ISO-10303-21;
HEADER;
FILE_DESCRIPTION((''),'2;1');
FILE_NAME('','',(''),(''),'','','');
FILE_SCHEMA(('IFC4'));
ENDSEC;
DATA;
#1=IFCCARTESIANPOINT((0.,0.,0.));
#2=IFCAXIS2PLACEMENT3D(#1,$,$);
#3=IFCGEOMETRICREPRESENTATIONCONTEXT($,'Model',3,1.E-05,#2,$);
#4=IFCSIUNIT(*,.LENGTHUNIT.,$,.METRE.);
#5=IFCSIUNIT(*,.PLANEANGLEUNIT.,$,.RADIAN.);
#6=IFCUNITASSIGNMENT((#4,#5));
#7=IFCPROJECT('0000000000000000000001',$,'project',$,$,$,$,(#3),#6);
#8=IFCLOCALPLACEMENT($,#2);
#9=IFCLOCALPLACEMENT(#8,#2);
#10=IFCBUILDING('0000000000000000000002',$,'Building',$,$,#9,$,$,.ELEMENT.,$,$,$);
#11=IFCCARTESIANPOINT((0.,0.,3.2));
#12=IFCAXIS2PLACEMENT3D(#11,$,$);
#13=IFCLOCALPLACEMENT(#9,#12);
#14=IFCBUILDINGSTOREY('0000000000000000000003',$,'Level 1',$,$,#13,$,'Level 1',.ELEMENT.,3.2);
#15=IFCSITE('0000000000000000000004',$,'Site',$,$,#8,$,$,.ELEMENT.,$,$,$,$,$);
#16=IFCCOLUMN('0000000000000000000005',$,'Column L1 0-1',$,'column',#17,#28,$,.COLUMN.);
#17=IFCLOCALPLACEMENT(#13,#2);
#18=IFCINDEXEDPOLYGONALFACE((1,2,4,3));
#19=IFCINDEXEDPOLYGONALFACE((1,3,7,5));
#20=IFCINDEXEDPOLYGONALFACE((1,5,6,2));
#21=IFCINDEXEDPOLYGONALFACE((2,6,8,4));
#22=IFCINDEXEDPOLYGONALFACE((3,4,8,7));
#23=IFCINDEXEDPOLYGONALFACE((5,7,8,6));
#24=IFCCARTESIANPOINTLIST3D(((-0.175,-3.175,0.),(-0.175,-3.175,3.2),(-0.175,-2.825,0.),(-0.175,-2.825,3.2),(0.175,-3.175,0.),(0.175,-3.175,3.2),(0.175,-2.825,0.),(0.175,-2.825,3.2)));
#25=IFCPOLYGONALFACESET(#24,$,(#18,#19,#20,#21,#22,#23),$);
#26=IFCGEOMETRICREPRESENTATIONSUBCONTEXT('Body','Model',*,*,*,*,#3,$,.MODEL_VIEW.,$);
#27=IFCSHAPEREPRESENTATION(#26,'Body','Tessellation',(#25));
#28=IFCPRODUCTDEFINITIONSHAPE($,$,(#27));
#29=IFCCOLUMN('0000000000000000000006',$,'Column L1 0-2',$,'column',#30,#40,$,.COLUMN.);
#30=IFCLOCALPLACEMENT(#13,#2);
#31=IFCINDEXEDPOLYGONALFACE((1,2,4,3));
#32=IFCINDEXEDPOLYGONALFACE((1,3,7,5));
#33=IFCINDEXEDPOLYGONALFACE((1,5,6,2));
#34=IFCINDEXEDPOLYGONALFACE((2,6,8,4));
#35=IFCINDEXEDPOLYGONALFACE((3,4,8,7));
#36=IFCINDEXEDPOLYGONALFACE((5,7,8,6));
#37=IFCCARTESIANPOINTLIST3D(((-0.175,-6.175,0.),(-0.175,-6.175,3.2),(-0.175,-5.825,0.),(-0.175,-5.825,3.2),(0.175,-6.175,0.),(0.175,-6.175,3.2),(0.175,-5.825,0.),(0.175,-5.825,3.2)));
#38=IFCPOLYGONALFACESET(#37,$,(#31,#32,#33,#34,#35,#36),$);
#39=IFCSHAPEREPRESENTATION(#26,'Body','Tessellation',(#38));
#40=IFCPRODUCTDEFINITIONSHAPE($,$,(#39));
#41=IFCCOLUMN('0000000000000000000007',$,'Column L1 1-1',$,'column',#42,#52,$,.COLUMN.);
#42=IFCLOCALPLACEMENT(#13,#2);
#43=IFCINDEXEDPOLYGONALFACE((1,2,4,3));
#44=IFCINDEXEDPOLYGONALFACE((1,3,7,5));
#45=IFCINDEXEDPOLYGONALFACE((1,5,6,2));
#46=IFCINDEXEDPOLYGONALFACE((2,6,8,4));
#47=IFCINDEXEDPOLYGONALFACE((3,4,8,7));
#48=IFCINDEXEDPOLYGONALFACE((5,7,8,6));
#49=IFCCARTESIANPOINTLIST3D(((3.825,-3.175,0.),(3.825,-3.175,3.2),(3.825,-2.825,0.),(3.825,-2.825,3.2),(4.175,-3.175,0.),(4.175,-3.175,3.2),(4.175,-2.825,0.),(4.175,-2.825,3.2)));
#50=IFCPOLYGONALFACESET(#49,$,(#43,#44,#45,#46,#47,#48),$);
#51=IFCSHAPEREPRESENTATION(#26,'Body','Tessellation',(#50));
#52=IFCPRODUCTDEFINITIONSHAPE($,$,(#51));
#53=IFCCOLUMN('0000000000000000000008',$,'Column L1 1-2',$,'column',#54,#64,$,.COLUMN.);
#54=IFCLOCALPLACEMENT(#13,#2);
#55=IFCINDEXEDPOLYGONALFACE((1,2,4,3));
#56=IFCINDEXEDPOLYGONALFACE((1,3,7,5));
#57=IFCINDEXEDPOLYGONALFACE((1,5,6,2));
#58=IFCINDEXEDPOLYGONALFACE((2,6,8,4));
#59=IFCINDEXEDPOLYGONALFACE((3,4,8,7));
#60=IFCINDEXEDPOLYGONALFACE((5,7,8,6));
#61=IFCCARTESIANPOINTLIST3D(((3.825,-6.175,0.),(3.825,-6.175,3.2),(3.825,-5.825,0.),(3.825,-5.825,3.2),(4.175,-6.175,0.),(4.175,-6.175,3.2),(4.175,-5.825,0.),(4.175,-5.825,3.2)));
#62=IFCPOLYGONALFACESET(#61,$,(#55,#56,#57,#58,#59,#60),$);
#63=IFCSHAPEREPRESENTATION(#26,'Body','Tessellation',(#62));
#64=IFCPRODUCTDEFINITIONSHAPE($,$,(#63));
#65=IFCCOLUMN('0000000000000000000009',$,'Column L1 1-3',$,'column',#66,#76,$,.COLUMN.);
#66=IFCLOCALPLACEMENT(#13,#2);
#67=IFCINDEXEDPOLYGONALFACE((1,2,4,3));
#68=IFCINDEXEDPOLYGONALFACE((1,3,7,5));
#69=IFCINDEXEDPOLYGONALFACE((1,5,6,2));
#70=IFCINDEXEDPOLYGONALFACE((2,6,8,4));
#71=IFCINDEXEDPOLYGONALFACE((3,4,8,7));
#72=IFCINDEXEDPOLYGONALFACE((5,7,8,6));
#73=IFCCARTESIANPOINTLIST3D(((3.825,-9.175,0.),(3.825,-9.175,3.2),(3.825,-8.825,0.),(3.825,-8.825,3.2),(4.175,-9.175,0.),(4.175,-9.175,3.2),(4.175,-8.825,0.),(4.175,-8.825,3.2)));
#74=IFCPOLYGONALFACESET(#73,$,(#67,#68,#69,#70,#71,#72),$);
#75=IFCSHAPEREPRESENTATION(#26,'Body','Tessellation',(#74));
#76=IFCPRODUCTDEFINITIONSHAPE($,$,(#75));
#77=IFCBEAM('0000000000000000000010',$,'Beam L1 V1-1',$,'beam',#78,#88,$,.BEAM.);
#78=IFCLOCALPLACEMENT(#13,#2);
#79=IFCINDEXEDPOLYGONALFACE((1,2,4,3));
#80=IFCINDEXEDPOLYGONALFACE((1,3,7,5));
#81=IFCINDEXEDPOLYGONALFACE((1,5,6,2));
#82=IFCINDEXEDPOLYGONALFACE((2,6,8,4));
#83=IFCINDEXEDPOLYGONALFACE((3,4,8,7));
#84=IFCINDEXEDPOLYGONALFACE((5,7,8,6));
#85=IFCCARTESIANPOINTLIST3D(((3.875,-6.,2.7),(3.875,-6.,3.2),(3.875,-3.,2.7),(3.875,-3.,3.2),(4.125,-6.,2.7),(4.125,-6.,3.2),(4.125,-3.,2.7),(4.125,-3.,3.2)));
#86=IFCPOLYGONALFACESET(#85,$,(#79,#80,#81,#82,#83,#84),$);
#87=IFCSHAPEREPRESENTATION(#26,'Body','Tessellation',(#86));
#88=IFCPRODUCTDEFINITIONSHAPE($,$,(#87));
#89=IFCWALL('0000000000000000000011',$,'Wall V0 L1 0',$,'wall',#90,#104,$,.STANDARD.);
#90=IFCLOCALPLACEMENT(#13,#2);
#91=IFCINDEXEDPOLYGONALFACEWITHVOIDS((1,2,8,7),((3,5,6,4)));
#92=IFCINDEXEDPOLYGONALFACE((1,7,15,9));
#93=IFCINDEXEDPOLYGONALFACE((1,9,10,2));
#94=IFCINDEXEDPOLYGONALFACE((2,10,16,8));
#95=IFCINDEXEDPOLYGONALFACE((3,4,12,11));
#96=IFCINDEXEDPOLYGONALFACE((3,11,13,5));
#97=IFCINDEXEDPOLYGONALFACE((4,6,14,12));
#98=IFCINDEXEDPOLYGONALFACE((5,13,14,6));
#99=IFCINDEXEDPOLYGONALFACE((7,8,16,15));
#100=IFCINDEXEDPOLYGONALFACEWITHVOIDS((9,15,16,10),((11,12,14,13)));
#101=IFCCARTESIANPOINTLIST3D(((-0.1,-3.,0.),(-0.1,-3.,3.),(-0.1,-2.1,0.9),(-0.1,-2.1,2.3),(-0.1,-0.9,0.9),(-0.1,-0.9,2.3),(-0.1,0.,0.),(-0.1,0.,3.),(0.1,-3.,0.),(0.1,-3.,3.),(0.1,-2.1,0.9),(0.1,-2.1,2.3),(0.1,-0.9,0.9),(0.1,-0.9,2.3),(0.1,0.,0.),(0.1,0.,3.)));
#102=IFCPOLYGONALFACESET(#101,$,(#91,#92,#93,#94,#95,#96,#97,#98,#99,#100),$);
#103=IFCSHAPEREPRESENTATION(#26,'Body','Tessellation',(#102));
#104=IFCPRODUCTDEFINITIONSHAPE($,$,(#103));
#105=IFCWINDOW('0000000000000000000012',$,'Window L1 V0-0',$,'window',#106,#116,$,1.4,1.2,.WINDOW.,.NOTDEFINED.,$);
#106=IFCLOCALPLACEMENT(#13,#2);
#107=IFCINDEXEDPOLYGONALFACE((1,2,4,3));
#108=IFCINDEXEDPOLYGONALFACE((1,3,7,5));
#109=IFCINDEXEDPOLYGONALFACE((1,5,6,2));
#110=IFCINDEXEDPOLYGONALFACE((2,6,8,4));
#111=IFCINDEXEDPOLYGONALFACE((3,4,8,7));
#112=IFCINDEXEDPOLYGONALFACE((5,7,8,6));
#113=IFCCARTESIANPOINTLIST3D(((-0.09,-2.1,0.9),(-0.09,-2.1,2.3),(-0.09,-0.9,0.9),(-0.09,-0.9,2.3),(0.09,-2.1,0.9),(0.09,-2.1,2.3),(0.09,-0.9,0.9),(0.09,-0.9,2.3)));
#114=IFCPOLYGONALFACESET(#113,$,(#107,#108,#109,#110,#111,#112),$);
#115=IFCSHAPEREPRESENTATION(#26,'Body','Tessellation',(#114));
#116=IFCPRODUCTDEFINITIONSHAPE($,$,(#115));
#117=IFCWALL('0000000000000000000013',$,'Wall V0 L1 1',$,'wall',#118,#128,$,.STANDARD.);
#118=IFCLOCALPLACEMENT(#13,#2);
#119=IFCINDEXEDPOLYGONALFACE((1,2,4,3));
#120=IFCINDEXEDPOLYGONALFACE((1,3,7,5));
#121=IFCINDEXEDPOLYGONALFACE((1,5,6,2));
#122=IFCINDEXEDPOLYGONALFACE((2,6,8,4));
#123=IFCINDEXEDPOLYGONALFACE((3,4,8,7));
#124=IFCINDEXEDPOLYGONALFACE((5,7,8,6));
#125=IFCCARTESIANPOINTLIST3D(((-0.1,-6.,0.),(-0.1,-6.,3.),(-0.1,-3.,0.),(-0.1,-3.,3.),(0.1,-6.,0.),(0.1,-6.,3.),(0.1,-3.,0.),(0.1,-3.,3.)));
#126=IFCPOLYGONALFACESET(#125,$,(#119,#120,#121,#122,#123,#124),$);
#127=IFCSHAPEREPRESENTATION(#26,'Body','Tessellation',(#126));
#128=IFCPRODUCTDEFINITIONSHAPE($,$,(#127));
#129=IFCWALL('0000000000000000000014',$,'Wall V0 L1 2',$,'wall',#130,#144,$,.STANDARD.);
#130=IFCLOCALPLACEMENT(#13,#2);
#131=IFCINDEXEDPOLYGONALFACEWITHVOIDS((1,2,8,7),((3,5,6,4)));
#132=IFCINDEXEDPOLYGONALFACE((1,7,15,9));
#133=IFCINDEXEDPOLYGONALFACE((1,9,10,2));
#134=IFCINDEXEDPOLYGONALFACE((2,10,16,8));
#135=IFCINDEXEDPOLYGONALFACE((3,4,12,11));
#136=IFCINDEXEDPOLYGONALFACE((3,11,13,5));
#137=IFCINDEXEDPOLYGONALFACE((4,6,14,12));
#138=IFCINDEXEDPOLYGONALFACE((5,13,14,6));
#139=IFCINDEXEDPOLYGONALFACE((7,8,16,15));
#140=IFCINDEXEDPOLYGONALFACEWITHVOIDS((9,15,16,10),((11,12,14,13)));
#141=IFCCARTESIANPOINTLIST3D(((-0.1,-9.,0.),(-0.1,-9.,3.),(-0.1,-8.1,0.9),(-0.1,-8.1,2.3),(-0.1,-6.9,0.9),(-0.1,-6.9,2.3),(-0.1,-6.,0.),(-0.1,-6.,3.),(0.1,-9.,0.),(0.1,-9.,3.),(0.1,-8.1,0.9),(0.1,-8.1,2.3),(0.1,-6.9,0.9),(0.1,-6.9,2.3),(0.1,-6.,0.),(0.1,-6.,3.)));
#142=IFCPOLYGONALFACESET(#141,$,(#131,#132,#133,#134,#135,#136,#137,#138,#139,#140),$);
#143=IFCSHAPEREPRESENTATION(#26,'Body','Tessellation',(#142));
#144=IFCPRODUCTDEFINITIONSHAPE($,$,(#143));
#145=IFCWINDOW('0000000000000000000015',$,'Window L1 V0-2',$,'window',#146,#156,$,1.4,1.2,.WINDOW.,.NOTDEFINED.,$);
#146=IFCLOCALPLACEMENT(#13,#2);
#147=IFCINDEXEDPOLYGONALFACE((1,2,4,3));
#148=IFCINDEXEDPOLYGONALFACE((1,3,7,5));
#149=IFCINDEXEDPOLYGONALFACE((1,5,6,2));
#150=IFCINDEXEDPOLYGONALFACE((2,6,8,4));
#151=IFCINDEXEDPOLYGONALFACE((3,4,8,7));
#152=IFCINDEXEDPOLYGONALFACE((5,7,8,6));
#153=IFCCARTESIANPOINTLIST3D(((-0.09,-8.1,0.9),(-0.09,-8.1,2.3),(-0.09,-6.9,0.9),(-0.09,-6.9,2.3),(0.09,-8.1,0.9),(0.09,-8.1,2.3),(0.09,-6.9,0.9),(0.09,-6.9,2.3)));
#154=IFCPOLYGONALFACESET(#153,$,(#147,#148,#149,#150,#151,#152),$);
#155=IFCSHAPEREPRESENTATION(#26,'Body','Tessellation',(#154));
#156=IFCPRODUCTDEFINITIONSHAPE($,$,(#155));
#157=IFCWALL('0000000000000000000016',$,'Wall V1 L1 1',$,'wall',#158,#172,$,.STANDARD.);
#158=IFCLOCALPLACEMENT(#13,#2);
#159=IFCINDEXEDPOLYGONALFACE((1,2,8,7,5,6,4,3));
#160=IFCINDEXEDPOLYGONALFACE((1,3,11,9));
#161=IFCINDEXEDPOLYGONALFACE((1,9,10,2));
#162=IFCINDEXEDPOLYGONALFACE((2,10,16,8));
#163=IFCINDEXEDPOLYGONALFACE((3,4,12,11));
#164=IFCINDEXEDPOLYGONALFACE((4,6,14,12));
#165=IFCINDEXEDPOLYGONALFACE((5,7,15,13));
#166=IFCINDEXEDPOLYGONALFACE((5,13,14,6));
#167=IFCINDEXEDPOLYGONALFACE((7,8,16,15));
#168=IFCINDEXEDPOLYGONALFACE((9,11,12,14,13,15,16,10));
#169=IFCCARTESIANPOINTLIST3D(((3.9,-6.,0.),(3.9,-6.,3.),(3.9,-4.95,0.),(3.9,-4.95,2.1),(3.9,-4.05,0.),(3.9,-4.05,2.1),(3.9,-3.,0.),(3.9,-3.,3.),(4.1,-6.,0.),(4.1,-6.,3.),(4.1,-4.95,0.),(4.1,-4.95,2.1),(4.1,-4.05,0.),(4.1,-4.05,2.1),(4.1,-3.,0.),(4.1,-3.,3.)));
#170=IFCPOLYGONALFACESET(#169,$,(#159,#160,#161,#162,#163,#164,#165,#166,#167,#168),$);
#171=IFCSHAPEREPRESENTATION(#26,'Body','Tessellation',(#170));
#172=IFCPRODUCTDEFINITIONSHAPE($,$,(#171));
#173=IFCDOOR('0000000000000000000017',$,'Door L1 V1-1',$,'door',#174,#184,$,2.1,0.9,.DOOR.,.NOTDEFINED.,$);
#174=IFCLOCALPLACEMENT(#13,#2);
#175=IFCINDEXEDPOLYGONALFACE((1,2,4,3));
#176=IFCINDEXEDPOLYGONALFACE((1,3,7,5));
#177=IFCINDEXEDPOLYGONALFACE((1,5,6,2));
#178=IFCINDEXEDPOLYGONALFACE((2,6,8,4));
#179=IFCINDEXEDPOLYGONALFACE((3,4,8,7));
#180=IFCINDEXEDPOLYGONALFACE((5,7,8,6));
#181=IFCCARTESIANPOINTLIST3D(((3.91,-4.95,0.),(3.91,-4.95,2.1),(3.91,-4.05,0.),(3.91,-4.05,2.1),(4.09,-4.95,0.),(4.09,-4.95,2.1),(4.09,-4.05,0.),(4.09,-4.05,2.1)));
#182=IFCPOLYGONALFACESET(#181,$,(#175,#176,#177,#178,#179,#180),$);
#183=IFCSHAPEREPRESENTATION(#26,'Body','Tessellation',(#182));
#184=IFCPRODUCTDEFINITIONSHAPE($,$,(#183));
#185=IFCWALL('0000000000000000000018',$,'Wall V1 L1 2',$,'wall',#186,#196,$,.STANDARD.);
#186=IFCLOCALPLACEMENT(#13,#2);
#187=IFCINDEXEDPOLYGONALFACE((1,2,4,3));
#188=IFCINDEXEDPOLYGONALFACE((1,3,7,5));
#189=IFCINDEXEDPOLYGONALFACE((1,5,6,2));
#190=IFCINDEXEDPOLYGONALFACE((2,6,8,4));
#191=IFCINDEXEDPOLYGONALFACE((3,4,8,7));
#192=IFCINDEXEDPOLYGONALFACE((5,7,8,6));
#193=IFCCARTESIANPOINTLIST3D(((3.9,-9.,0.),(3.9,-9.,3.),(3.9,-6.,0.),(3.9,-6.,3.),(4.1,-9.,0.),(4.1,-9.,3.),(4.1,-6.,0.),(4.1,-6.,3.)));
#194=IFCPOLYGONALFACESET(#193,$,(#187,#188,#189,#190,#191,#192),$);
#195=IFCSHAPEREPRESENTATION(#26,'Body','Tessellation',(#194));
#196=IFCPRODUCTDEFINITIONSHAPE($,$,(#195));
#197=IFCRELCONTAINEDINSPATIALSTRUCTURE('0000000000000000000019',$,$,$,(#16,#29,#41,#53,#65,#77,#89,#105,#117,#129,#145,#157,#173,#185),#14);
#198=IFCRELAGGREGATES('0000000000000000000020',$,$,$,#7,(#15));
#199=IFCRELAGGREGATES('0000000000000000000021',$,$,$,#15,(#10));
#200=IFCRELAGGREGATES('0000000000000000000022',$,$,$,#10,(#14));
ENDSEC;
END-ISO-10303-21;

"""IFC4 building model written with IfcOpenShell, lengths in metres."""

from ifc_helpers import new_model, si_unit, frame, frame_2d, origin, origin_2d, place, context, subcontext, project, spatial, rectangle, extrude, element, fill, save


model = new_model("IFC4")

# Units and contexts
model_context = context("Model", 3, precision=1e-05, world=origin())
body_context = subcontext(model_context, "Body", "Model", "MODEL_VIEW")
ifc_project = project(units=[si_unit("LENGTHUNIT", "METRE"), si_unit("PLANEANGLEUNIT", "RADIAN")], contexts=[model_context])

# Site, building, storey
site_placement = place(None, origin())
site = spatial("IfcSite", under=ifc_project, at=site_placement, Name="Site", CompositionType="ELEMENT")
building_placement = place(site_placement, origin())
building = spatial("IfcBuilding", under=site, at=building_placement, Name="Building", CompositionType="ELEMENT")
storey_placement = place(building_placement, frame((0.0, 0.0, 3.2)))
storey = spatial("IfcBuildingStorey", under=building, at=storey_placement, Name="Level 1", LongName="Level 1", CompositionType="ELEMENT", Elevation=3.2)

# Columns
for number, where, name in (
    (1, (0.0, -3.0, 0.0), "Column L1 0-1"),
    (2, (0.0, -6.0, 0.0), "Column L1 0-2"),
    (3, (4.0, -3.0, 0.0), "Column L1 1-1"),
    (4, (4.0, -6.0, 0.0), "Column L1 1-2"),
    (5, (4.0, -9.0, 0.0), "Column L1 1-3"),
):
    element("IfcColumn", number, at=place(storey_placement, frame(where)), inside=storey, Name=name, ObjectType="column", PredefinedType="COLUMN", context=body_context, shape_type="SweptSolid", body=[
        extrude(rectangle(XDim=0.35, YDim=0.35, at=origin_2d()), origin(), (0.0, 0.0, 1.0), 3.2),
    ])

# Beam
beam_placement = place(storey_placement, frame((4.0, -3.0, 2.95), z_axis=(0.0, -1.0, 0.0), x_axis=(0.0, 0.0, 1.0)))
element("IfcBeam", 6, at=beam_placement, inside=storey, Name="Beam L1 V1-1", ObjectType="beam", PredefinedType="BEAM", context=body_context, shape_type="SweptSolid", body=[
    extrude(rectangle(XDim=0.5, YDim=0.25, at=origin_2d()), origin(), (0.0, 0.0, 1.0), 3.0),
])

# Wall, opening, window
wall_1_placement = place(storey_placement, frame((0.0, 0.0, 0.0), z_axis=(0.0, 0.0, 1.0), x_axis=(0.0, -1.0, 0.0)))
wall_1 = element("IfcWall", 7, at=wall_1_placement, inside=storey, Name="Wall V0 L1 0", ObjectType="wall", PredefinedType="STANDARD", context=body_context, shape_type="SweptSolid", body=[
    extrude(rectangle(XDim=3.0, YDim=0.2, at=frame_2d((1.5, 0.0))), origin(), (0.0, 0.0, 1.0), 3.0),
])
opening_1_placement = place(storey_placement, frame((0.0, -1.5, 0.9), z_axis=(0.0, 0.0, 1.0), x_axis=(0.0, -1.0, 0.0)))
opening_1 = element("IfcOpeningElement", 8, at=opening_1_placement, cuts=wall_1, ObjectType="Opening", PredefinedType="OPENING", context=body_context, shape_type="SweptSolid", body=[
    extrude(rectangle(XDim=1.2, YDim=0.22, at=origin_2d()), origin(), (0.0, 0.0, 1.0), 1.4),
])
window_1_placement = place(storey_placement, frame((0.0, -1.5, 0.9), z_axis=(0.0, 0.0, 1.0), x_axis=(0.0, -1.0, 0.0)))
window_1 = element("IfcWindow", 9, at=window_1_placement, inside=storey, Name="Window L1 V0-0", ObjectType="window", OverallHeight=1.4, OverallWidth=1.2, PartitioningType="NOTDEFINED", PredefinedType="WINDOW", context=body_context, shape_type="SweptSolid", body=[
    extrude(rectangle(XDim=1.2, YDim=0.18, at=origin_2d()), origin(), (0.0, 0.0, 1.0), 1.4),
])
fill(opening_1, window_1)

# Wall
wall_2_placement = place(storey_placement, frame((0.0, -3.0, 0.0), z_axis=(0.0, 0.0, 1.0), x_axis=(0.0, -1.0, 0.0)))
element("IfcWall", 10, at=wall_2_placement, inside=storey, Name="Wall V0 L1 1", ObjectType="wall", PredefinedType="STANDARD", context=body_context, shape_type="SweptSolid", body=[
    extrude(rectangle(XDim=3.0, YDim=0.2, at=frame_2d((1.5, 0.0))), origin(), (0.0, 0.0, 1.0), 3.0),
])

# Wall, opening, window
wall_3_placement = place(storey_placement, frame((0.0, -6.0, 0.0), z_axis=(0.0, 0.0, 1.0), x_axis=(0.0, -1.0, 0.0)))
wall_3 = element("IfcWall", 11, at=wall_3_placement, inside=storey, Name="Wall V0 L1 2", ObjectType="wall", PredefinedType="STANDARD", context=body_context, shape_type="SweptSolid", body=[
    extrude(rectangle(XDim=3.0, YDim=0.2, at=frame_2d((1.5, 0.0))), origin(), (0.0, 0.0, 1.0), 3.0),
])
opening_2_placement = place(storey_placement, frame((0.0, -7.5, 0.9), z_axis=(0.0, 0.0, 1.0), x_axis=(0.0, -1.0, 0.0)))
opening_2 = element("IfcOpeningElement", 12, at=opening_2_placement, cuts=wall_3, ObjectType="Opening", PredefinedType="OPENING", context=body_context, shape_type="SweptSolid", body=[
    extrude(rectangle(XDim=1.2, YDim=0.22, at=origin_2d()), origin(), (0.0, 0.0, 1.0), 1.4),
])
window_2_placement = place(storey_placement, frame((0.0, -7.5, 0.9), z_axis=(0.0, 0.0, 1.0), x_axis=(0.0, -1.0, 0.0)))
window_2 = element("IfcWindow", 13, at=window_2_placement, inside=storey, Name="Window L1 V0-2", ObjectType="window", OverallHeight=1.4, OverallWidth=1.2, PartitioningType="NOTDEFINED", PredefinedType="WINDOW", context=body_context, shape_type="SweptSolid", body=[
    extrude(rectangle(XDim=1.2, YDim=0.18, at=origin_2d()), origin(), (0.0, 0.0, 1.0), 1.4),
])
fill(opening_2, window_2)

# Wall, opening, door
wall_4_placement = place(storey_placement, frame((4.0, -3.0, 0.0), z_axis=(0.0, 0.0, 1.0), x_axis=(0.0, -1.0, 0.0)))
wall_4 = element("IfcWall", 14, at=wall_4_placement, inside=storey, Name="Wall V1 L1 1", ObjectType="wall", PredefinedType="STANDARD", context=body_context, shape_type="SweptSolid", body=[
    extrude(rectangle(XDim=3.0, YDim=0.2, at=frame_2d((1.5, 0.0))), origin(), (0.0, 0.0, 1.0), 3.0),
])
opening_3_placement = place(storey_placement, frame((4.0, -4.5, 0.0), z_axis=(0.0, 0.0, 1.0), x_axis=(0.0, -1.0, 0.0)))
opening_3 = element("IfcOpeningElement", 15, at=opening_3_placement, cuts=wall_4, ObjectType="Opening", PredefinedType="OPENING", context=body_context, shape_type="SweptSolid", body=[
    extrude(rectangle(XDim=0.9, YDim=0.22, at=origin_2d()), origin(), (0.0, 0.0, 1.0), 2.1),
])
door_placement = place(storey_placement, frame((4.0, -4.5, 0.0), z_axis=(0.0, 0.0, 1.0), x_axis=(0.0, -1.0, 0.0)))
door = element("IfcDoor", 16, at=door_placement, inside=storey, Name="Door L1 V1-1", ObjectType="door", OperationType="NOTDEFINED", OverallHeight=2.1, OverallWidth=0.9, PredefinedType="DOOR", context=body_context, shape_type="SweptSolid", body=[
    extrude(rectangle(XDim=0.9, YDim=0.18, at=origin_2d()), origin(), (0.0, 0.0, 1.0), 2.1),
])
fill(opening_3, door)

# Wall
wall_5_placement = place(storey_placement, frame((4.0, -6.0, 0.0), z_axis=(0.0, 0.0, 1.0), x_axis=(0.0, -1.0, 0.0)))
element("IfcWall", 17, at=wall_5_placement, inside=storey, Name="Wall V1 L1 2", ObjectType="wall", PredefinedType="STANDARD", context=body_context, shape_type="SweptSolid", body=[
    extrude(rectangle(XDim=3.0, YDim=0.2, at=frame_2d((1.5, 0.0))), origin(), (0.0, 0.0, 1.0), 3.0),
])

save(model, "model.ifc")
